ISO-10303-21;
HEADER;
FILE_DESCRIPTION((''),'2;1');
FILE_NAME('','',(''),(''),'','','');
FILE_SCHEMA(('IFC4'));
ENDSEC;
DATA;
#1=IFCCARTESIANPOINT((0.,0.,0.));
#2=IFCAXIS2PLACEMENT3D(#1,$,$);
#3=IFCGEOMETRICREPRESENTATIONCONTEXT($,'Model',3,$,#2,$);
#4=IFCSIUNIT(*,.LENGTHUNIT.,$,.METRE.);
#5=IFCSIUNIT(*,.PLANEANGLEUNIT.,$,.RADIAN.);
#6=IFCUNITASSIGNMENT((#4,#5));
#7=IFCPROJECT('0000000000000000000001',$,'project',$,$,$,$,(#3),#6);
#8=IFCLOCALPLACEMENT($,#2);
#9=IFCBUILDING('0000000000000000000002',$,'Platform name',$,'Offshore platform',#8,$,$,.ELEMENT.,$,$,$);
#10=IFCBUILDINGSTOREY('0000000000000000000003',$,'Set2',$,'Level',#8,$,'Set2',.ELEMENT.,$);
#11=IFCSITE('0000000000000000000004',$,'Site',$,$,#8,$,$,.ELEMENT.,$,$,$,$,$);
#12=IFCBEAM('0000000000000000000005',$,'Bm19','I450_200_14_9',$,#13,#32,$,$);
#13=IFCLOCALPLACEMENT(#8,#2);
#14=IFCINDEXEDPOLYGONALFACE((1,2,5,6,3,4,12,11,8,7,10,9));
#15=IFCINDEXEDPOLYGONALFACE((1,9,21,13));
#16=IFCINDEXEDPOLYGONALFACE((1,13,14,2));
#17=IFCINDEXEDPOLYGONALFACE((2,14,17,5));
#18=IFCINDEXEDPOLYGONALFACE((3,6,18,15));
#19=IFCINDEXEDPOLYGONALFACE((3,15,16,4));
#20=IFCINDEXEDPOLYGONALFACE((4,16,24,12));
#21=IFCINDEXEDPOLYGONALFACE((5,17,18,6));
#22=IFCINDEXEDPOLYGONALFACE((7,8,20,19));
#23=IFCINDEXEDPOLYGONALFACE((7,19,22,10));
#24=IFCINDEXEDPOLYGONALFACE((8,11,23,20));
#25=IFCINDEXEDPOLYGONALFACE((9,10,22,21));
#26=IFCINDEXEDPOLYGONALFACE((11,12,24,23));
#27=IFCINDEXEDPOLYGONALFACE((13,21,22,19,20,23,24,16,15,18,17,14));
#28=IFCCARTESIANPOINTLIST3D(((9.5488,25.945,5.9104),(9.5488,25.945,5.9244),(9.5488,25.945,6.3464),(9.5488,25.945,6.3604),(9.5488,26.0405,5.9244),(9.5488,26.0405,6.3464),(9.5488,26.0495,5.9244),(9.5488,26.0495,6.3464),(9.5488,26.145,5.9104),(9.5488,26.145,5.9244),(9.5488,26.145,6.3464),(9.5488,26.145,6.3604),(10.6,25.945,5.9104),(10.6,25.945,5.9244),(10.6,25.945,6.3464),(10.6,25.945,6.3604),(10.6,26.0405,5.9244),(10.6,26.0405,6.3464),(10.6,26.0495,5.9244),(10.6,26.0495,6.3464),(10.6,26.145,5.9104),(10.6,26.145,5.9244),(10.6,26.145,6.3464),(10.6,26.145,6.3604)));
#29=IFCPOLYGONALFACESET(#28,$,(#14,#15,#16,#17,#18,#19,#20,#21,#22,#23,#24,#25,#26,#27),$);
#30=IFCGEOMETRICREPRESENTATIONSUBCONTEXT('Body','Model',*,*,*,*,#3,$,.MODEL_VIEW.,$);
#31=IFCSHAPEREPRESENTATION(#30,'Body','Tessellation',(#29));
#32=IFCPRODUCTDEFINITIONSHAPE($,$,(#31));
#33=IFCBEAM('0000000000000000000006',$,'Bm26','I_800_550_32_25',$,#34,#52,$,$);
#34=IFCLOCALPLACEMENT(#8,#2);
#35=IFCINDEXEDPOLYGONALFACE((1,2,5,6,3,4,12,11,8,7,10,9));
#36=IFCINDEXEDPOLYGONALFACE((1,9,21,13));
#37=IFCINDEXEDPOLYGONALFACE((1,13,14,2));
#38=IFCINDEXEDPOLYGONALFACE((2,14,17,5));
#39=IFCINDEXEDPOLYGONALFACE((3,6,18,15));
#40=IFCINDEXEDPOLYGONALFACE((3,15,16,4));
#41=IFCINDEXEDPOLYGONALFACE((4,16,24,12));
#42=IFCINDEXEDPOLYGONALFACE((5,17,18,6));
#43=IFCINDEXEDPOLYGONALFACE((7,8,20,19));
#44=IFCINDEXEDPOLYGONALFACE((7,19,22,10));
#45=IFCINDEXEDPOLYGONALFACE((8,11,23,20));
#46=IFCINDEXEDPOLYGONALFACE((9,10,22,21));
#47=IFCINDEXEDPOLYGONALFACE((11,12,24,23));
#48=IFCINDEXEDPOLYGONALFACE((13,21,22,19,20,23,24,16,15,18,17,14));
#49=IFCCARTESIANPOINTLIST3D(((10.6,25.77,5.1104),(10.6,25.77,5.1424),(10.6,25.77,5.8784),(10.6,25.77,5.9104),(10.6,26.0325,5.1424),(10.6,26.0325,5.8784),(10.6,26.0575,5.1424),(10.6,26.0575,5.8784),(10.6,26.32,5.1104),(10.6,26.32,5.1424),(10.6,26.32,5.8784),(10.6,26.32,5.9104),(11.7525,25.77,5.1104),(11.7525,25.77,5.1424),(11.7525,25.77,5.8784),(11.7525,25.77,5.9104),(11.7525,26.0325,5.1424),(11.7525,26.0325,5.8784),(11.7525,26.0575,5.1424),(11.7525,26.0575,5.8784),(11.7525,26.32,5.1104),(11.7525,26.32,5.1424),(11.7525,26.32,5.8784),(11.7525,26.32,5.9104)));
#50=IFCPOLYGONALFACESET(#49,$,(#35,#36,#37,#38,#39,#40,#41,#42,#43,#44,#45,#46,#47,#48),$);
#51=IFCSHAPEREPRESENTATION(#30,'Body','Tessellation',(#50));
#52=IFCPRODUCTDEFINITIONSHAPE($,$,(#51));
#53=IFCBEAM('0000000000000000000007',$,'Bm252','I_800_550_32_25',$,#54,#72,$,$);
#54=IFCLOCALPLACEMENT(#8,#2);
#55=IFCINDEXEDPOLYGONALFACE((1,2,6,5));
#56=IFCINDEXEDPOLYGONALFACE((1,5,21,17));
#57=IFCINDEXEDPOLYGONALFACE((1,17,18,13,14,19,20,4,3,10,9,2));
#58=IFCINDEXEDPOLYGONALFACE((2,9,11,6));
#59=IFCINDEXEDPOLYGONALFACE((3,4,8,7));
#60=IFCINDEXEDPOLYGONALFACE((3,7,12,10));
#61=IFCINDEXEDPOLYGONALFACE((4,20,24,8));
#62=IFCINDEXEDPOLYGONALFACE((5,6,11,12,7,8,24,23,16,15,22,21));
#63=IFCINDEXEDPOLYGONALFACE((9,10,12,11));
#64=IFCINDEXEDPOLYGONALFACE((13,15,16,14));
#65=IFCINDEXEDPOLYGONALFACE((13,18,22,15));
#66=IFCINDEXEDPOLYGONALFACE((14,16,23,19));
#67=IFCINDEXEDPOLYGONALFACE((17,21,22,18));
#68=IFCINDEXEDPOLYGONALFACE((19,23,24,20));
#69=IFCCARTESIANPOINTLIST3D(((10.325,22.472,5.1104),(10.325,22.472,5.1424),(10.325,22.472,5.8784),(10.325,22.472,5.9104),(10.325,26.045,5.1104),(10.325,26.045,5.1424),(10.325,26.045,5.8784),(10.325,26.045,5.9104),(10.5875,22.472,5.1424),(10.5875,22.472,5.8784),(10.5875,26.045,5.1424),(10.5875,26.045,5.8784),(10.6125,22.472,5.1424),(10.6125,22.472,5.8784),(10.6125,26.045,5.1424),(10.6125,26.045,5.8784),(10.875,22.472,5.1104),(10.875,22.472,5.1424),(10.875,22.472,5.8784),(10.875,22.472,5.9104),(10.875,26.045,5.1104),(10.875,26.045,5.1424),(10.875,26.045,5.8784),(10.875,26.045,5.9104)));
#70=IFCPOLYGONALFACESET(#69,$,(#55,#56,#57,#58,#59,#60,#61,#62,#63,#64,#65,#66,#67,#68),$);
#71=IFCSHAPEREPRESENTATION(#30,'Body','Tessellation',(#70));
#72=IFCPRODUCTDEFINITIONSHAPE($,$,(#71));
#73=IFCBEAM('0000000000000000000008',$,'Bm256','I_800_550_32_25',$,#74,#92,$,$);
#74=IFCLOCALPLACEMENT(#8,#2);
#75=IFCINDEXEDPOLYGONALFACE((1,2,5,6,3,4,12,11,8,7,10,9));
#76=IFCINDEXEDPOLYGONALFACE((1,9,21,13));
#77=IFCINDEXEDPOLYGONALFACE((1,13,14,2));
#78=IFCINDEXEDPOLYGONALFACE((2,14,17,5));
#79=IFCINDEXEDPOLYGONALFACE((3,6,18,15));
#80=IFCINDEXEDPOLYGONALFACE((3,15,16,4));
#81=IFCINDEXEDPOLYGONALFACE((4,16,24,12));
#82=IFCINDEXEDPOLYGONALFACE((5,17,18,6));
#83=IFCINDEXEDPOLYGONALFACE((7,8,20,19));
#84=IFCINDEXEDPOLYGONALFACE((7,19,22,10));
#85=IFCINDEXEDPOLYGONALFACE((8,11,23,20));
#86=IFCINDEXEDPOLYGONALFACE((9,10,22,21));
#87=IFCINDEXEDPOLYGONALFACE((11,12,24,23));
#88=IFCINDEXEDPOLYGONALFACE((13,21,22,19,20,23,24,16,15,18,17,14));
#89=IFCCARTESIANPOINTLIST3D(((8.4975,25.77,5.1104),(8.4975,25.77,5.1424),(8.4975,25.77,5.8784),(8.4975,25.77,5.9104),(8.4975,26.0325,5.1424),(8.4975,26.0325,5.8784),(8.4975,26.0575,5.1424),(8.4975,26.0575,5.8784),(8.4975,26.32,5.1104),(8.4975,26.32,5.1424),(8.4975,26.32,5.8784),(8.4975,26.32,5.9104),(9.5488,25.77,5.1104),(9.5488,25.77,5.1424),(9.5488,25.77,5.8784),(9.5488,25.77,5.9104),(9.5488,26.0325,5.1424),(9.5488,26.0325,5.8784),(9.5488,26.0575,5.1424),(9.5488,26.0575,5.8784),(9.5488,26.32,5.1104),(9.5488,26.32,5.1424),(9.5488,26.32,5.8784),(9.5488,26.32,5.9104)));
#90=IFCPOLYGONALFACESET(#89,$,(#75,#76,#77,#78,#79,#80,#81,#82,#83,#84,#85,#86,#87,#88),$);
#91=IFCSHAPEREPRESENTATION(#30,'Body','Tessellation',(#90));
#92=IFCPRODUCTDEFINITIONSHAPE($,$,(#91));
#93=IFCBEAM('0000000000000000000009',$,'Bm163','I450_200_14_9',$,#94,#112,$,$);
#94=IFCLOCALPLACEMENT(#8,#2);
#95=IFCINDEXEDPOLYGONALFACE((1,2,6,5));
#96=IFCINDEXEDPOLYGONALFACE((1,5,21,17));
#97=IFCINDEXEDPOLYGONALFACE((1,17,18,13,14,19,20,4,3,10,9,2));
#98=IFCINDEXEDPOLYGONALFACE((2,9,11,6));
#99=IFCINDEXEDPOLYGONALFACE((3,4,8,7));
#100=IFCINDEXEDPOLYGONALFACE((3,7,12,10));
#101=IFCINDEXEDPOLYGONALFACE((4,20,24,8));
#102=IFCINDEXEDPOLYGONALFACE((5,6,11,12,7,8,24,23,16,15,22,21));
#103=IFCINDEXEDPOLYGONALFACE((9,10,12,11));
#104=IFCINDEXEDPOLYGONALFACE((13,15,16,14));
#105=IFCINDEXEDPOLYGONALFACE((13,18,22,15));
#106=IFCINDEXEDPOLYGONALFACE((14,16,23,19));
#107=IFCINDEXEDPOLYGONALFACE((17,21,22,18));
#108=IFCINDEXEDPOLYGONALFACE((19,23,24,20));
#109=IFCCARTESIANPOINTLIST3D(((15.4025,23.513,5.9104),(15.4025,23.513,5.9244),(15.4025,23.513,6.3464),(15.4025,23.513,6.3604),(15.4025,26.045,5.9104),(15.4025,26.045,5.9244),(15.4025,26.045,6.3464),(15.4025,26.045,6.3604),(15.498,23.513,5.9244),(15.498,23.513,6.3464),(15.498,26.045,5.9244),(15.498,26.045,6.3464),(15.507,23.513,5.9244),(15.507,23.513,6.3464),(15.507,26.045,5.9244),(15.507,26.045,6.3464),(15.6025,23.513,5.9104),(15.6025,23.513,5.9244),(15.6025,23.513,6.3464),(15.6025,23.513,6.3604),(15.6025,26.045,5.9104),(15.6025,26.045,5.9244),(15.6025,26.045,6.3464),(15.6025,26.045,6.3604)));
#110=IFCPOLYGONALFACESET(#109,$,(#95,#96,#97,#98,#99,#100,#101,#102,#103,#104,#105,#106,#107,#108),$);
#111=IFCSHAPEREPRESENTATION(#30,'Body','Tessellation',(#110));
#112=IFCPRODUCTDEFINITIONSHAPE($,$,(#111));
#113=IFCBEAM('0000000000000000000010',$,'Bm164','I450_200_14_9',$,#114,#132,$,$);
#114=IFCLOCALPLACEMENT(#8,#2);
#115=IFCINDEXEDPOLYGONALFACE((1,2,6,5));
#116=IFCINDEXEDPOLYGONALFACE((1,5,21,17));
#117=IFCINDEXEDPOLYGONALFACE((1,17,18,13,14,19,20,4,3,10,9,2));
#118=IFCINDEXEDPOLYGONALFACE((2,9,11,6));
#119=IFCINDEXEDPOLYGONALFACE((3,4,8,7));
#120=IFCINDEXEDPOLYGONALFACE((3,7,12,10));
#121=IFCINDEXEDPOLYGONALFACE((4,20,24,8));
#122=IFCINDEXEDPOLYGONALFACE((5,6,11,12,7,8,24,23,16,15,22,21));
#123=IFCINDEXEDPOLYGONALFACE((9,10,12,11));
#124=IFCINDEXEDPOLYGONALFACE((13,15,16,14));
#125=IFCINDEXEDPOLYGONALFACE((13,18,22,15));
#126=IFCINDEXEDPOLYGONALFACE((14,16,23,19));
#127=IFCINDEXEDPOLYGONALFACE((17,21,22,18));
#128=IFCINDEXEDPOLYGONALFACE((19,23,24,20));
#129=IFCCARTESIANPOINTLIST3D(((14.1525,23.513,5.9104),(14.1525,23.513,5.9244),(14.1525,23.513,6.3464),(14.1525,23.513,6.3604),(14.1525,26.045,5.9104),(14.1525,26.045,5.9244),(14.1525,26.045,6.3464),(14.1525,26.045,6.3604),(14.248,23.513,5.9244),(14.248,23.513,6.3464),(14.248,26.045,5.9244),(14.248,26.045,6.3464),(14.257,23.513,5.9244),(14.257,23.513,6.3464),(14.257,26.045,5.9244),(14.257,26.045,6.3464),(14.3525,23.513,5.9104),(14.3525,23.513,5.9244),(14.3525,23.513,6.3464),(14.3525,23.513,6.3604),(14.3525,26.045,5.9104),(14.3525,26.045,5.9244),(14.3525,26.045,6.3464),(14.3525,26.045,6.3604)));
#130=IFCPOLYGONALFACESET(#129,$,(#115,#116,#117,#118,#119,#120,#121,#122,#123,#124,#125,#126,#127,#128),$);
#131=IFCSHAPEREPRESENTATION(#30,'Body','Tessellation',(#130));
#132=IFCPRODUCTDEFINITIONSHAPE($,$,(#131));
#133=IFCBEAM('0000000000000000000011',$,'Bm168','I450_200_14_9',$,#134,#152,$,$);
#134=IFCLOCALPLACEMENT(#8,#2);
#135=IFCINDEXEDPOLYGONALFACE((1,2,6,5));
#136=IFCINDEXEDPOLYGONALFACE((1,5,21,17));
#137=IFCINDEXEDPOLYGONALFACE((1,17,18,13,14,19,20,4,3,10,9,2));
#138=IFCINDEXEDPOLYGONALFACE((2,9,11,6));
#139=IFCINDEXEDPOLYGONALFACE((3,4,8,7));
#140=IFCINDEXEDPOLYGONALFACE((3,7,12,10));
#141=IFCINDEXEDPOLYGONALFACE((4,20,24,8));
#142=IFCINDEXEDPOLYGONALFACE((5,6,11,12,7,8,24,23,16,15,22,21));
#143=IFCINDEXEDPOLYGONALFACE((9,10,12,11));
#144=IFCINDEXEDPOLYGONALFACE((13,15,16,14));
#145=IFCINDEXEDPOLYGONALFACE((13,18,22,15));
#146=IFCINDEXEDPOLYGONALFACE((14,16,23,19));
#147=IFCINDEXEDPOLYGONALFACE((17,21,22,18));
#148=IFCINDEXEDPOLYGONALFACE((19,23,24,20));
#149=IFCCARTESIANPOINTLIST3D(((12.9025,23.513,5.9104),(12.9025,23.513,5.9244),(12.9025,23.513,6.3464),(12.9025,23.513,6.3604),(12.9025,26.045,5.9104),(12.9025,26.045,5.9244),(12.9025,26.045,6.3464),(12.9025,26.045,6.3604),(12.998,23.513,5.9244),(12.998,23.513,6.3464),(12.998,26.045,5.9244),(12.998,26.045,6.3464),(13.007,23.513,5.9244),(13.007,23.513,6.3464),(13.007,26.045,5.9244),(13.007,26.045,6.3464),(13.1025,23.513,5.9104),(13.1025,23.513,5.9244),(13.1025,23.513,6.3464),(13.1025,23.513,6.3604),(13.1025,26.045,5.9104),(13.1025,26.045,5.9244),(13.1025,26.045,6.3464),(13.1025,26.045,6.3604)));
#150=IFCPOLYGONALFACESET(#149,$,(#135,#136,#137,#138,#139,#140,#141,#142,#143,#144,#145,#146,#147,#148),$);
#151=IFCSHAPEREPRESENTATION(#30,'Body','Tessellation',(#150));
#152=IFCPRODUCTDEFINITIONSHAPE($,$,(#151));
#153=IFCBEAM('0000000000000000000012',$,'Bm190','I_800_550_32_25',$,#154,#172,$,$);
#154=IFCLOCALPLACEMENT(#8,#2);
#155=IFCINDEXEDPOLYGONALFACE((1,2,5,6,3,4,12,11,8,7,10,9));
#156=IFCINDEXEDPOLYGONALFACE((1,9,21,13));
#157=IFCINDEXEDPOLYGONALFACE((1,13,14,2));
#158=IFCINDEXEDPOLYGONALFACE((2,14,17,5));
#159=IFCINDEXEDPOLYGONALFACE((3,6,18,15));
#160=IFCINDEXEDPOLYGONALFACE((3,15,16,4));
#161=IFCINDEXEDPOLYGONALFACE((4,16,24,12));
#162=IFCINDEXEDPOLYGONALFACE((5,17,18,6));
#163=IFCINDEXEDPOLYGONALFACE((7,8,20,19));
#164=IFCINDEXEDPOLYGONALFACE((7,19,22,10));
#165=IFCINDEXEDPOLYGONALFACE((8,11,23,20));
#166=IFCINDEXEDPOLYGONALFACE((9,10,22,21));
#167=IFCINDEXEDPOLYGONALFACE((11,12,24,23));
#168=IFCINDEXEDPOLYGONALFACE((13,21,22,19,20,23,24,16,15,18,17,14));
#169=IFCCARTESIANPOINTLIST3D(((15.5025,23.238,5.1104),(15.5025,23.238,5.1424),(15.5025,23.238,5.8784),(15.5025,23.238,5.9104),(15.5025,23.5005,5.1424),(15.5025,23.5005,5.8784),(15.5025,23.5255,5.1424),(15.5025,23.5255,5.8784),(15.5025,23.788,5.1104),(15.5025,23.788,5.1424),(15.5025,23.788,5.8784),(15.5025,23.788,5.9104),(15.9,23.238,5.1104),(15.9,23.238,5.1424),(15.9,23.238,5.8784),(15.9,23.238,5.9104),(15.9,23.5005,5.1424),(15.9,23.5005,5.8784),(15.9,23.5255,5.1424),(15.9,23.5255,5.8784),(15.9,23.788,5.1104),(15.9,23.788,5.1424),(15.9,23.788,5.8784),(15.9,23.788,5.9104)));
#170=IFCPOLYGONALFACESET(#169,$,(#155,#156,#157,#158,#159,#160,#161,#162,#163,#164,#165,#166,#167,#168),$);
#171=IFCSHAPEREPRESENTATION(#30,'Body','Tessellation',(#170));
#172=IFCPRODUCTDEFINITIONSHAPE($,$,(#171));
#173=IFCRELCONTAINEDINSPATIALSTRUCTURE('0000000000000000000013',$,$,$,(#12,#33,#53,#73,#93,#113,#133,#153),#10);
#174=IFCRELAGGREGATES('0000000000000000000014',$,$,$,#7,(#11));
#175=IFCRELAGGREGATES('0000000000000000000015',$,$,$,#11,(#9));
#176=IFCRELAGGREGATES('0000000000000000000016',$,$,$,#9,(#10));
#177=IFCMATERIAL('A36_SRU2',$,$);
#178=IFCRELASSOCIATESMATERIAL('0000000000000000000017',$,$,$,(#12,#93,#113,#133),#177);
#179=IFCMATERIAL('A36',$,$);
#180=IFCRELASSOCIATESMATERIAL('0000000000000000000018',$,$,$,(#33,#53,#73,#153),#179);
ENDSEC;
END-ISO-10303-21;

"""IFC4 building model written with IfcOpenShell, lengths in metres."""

from ifc_helpers import new_model, si_unit, frame, origin, origin_2d, place, context, subcontext, project, spatial, i_section, extrude, source, transform, mapped, material, element, save


model = new_model("IFC4")

# Units and contexts
model_context = context("Model", 3, world=origin())
body_context = subcontext(model_context, "Body", "Model", "MODEL_VIEW")
ifc_project = project(units=[si_unit("LENGTHUNIT", "METRE"), si_unit("PLANEANGLEUNIT", "RADIAN")], contexts=[model_context])

# Site, building, storey
placement_1 = place(None, origin())
site = spatial("IfcSite", under=ifc_project, at=placement_1, Name="Site", CompositionType="ELEMENT")
building = spatial("IfcBuilding", under=site, at=placement_1, Name="Platform name", ObjectType="Offshore platform", CompositionType="ELEMENT")
storey = spatial("IfcBuildingStorey", under=building, at=placement_1, Name="Set2", ObjectType="Level", LongName="Set2", CompositionType="ELEMENT")

# Beams
ifc_material_1 = material(Name="A36_SRU2")
shared_shape_1 = source(origin(), body_context, "Body", "SweptSolid", [
    extrude(i_section(OverallWidth=0.2, OverallDepth=0.45, WebThickness=0.009, FlangeThickness=0.014, FilletRadius=0.0, at=origin_2d()), frame((0.0, 0.0, 0.0), z_axis=(-1.0, 0.0, 0.0), x_axis=(0.0, -1.0, 0.0)), (0.0, 0.0, 1.0), 1.0513),
])
placement_2 = place(None, origin())
placement_3 = place(placement_2, origin())
placement_4 = place(placement_3, origin())
beam_1_placement = place(placement_4, frame((10.6, 26.045, 6.1354)))
element("IfcBeam", 1, at=beam_1_placement, inside=storey, material=ifc_material_1, Name="Bm19", Description="I450_200_14_9", context=body_context, shape_type="MappedRepresentation", body=[
    mapped(shared_shape_1, transform((0.0, 0.0, 0.0), scale=1.0)),
])
ifc_material_2 = material(Name="A36")
shared_shape_2 = source(origin(), body_context, "Body", "SweptSolid", [
    extrude(i_section(OverallWidth=0.55, OverallDepth=0.8, WebThickness=0.025, FlangeThickness=0.032, FilletRadius=0.0, at=origin_2d()), frame((0.0, 0.0, 0.0), z_axis=(1.0, 0.0, 0.0), x_axis=(0.0, 1.0, 0.0)), (0.0, 0.0, 1.0), 1.1525),
])
placement_5 = place(None, origin())
placement_6 = place(placement_5, origin())
placement_7 = place(placement_6, origin())
beam_2_placement = place(placement_7, frame((10.6, 26.045, 5.5104)))
element("IfcBeam", 2, at=beam_2_placement, inside=storey, material=ifc_material_2, Name="Bm26", Description="I_800_550_32_25", context=body_context, shape_type="MappedRepresentation", body=[
    mapped(shared_shape_2, transform((0.0, 0.0, 0.0), scale=1.0)),
])
shared_shape_3 = source(origin(), body_context, "Body", "SweptSolid", [
    extrude(i_section(OverallWidth=0.55, OverallDepth=0.8, WebThickness=0.025, FlangeThickness=0.032, FilletRadius=0.0, at=origin_2d()), frame((0.0, 0.0, 0.0), z_axis=(0.0, -1.0, 0.0), x_axis=(1.0, 0.0, 0.0)), (0.0, 0.0, 1.0), 3.573),
])
placement_8 = place(None, origin())
placement_9 = place(placement_8, origin())
placement_10 = place(placement_9, origin())
beam_3_placement = place(placement_10, frame((10.6, 26.045, 5.5104)))
element("IfcBeam", 3, at=beam_3_placement, inside=storey, material=ifc_material_2, Name="Bm252", Description="I_800_550_32_25", context=body_context, shape_type="MappedRepresentation", body=[
    mapped(shared_shape_3, transform((0.0, 0.0, 0.0), scale=1.0)),
])
shared_shape_4 = source(origin(), body_context, "Body", "SweptSolid", [
    extrude(i_section(OverallWidth=0.55, OverallDepth=0.8, WebThickness=0.025, FlangeThickness=0.032, FilletRadius=0.0, at=origin_2d()), frame((0.0, 0.0, 0.0), z_axis=(1.0, 0.0, 0.0), x_axis=(0.0, 1.0, 0.0)), (0.0, 0.0, 1.0), 1.0513),
])
placement_11 = place(None, origin())
placement_12 = place(placement_11, origin())
placement_13 = place(placement_12, origin())
beam_4_placement = place(placement_13, frame((8.4975, 26.045, 5.5104)))
element("IfcBeam", 4, at=beam_4_placement, inside=storey, material=ifc_material_2, Name="Bm256", Description="I_800_550_32_25", context=body_context, shape_type="MappedRepresentation", body=[
    mapped(shared_shape_4, transform((0.0, 0.0, 0.0), scale=1.0)),
])
shared_shape_5 = source(origin(), body_context, "Body", "SweptSolid", [
    extrude(i_section(OverallWidth=0.2, OverallDepth=0.45, WebThickness=0.009, FlangeThickness=0.014, FilletRadius=0.0, at=origin_2d()), frame((0.0, 0.0, 0.0), z_axis=(0.0, 1.0, 0.0), x_axis=(-1.0, 0.0, 0.0)), (0.0, 0.0, 1.0), 2.532),
])
placement_14 = place(None, origin())
placement_15 = place(placement_14, origin())
placement_16 = place(placement_15, origin())
beam_5_placement = place(placement_16, frame((15.5025, 23.513, 6.1354)))
element("IfcBeam", 5, at=beam_5_placement, inside=storey, material=ifc_material_1, Name="Bm163", Description="I450_200_14_9", context=body_context, shape_type="MappedRepresentation", body=[
    mapped(shared_shape_5, transform((0.0, 0.0, 0.0), scale=1.0)),
])
shared_shape_6 = source(origin(), body_context, "Body", "SweptSolid", [
    extrude(i_section(OverallWidth=0.2, OverallDepth=0.45, WebThickness=0.009, FlangeThickness=0.014, FilletRadius=0.0, at=origin_2d()), frame((0.0, 0.0, 0.0), z_axis=(0.0, 1.0, 0.0), x_axis=(-1.0, 0.0, 0.0)), (0.0, 0.0, 1.0), 2.532),
])
placement_17 = place(None, origin())
placement_18 = place(placement_17, origin())
placement_19 = place(placement_18, origin())
beam_6_placement = place(placement_19, frame((14.2525, 23.513, 6.1354)))
element("IfcBeam", 6, at=beam_6_placement, inside=storey, material=ifc_material_1, Name="Bm164", Description="I450_200_14_9", context=body_context, shape_type="MappedRepresentation", body=[
    mapped(shared_shape_6, transform((0.0, 0.0, 0.0), scale=1.0)),
])
shared_shape_7 = source(origin(), body_context, "Body", "SweptSolid", [
    extrude(i_section(OverallWidth=0.2, OverallDepth=0.45, WebThickness=0.009, FlangeThickness=0.014, FilletRadius=0.0, at=origin_2d()), frame((0.0, 0.0, 0.0), z_axis=(0.0, 1.0, 0.0), x_axis=(-1.0, 0.0, 0.0)), (0.0, 0.0, 1.0), 2.532),
])
placement_20 = place(None, origin())
placement_21 = place(placement_20, origin())
placement_22 = place(placement_21, origin())
beam_7_placement = place(placement_22, frame((13.0025, 23.513, 6.1354)))
element("IfcBeam", 7, at=beam_7_placement, inside=storey, material=ifc_material_1, Name="Bm168", Description="I450_200_14_9", context=body_context, shape_type="MappedRepresentation", body=[
    mapped(shared_shape_7, transform((0.0, 0.0, 0.0), scale=1.0)),
])
shared_shape_8 = source(origin(), body_context, "Body", "SweptSolid", [
    extrude(i_section(OverallWidth=0.55, OverallDepth=0.8, WebThickness=0.025, FlangeThickness=0.032, FilletRadius=0.0, at=origin_2d()), frame((0.0, 0.0, 0.0), z_axis=(1.0, 0.0, 0.0), x_axis=(0.0, 1.0, 0.0)), (0.0, 0.0, 1.0), 0.3975),
])
placement_23 = place(None, origin())
placement_24 = place(placement_23, origin())
placement_25 = place(placement_24, origin())
beam_8_placement = place(placement_25, frame((15.5025, 23.513, 5.5104)))
element("IfcBeam", 8, at=beam_8_placement, inside=storey, material=ifc_material_2, Name="Bm190", Description="I_800_550_32_25", context=body_context, shape_type="MappedRepresentation", body=[
    mapped(shared_shape_8, transform((0.0, 0.0, 0.0), scale=1.0)),
])

save(model, "model.ifc")
